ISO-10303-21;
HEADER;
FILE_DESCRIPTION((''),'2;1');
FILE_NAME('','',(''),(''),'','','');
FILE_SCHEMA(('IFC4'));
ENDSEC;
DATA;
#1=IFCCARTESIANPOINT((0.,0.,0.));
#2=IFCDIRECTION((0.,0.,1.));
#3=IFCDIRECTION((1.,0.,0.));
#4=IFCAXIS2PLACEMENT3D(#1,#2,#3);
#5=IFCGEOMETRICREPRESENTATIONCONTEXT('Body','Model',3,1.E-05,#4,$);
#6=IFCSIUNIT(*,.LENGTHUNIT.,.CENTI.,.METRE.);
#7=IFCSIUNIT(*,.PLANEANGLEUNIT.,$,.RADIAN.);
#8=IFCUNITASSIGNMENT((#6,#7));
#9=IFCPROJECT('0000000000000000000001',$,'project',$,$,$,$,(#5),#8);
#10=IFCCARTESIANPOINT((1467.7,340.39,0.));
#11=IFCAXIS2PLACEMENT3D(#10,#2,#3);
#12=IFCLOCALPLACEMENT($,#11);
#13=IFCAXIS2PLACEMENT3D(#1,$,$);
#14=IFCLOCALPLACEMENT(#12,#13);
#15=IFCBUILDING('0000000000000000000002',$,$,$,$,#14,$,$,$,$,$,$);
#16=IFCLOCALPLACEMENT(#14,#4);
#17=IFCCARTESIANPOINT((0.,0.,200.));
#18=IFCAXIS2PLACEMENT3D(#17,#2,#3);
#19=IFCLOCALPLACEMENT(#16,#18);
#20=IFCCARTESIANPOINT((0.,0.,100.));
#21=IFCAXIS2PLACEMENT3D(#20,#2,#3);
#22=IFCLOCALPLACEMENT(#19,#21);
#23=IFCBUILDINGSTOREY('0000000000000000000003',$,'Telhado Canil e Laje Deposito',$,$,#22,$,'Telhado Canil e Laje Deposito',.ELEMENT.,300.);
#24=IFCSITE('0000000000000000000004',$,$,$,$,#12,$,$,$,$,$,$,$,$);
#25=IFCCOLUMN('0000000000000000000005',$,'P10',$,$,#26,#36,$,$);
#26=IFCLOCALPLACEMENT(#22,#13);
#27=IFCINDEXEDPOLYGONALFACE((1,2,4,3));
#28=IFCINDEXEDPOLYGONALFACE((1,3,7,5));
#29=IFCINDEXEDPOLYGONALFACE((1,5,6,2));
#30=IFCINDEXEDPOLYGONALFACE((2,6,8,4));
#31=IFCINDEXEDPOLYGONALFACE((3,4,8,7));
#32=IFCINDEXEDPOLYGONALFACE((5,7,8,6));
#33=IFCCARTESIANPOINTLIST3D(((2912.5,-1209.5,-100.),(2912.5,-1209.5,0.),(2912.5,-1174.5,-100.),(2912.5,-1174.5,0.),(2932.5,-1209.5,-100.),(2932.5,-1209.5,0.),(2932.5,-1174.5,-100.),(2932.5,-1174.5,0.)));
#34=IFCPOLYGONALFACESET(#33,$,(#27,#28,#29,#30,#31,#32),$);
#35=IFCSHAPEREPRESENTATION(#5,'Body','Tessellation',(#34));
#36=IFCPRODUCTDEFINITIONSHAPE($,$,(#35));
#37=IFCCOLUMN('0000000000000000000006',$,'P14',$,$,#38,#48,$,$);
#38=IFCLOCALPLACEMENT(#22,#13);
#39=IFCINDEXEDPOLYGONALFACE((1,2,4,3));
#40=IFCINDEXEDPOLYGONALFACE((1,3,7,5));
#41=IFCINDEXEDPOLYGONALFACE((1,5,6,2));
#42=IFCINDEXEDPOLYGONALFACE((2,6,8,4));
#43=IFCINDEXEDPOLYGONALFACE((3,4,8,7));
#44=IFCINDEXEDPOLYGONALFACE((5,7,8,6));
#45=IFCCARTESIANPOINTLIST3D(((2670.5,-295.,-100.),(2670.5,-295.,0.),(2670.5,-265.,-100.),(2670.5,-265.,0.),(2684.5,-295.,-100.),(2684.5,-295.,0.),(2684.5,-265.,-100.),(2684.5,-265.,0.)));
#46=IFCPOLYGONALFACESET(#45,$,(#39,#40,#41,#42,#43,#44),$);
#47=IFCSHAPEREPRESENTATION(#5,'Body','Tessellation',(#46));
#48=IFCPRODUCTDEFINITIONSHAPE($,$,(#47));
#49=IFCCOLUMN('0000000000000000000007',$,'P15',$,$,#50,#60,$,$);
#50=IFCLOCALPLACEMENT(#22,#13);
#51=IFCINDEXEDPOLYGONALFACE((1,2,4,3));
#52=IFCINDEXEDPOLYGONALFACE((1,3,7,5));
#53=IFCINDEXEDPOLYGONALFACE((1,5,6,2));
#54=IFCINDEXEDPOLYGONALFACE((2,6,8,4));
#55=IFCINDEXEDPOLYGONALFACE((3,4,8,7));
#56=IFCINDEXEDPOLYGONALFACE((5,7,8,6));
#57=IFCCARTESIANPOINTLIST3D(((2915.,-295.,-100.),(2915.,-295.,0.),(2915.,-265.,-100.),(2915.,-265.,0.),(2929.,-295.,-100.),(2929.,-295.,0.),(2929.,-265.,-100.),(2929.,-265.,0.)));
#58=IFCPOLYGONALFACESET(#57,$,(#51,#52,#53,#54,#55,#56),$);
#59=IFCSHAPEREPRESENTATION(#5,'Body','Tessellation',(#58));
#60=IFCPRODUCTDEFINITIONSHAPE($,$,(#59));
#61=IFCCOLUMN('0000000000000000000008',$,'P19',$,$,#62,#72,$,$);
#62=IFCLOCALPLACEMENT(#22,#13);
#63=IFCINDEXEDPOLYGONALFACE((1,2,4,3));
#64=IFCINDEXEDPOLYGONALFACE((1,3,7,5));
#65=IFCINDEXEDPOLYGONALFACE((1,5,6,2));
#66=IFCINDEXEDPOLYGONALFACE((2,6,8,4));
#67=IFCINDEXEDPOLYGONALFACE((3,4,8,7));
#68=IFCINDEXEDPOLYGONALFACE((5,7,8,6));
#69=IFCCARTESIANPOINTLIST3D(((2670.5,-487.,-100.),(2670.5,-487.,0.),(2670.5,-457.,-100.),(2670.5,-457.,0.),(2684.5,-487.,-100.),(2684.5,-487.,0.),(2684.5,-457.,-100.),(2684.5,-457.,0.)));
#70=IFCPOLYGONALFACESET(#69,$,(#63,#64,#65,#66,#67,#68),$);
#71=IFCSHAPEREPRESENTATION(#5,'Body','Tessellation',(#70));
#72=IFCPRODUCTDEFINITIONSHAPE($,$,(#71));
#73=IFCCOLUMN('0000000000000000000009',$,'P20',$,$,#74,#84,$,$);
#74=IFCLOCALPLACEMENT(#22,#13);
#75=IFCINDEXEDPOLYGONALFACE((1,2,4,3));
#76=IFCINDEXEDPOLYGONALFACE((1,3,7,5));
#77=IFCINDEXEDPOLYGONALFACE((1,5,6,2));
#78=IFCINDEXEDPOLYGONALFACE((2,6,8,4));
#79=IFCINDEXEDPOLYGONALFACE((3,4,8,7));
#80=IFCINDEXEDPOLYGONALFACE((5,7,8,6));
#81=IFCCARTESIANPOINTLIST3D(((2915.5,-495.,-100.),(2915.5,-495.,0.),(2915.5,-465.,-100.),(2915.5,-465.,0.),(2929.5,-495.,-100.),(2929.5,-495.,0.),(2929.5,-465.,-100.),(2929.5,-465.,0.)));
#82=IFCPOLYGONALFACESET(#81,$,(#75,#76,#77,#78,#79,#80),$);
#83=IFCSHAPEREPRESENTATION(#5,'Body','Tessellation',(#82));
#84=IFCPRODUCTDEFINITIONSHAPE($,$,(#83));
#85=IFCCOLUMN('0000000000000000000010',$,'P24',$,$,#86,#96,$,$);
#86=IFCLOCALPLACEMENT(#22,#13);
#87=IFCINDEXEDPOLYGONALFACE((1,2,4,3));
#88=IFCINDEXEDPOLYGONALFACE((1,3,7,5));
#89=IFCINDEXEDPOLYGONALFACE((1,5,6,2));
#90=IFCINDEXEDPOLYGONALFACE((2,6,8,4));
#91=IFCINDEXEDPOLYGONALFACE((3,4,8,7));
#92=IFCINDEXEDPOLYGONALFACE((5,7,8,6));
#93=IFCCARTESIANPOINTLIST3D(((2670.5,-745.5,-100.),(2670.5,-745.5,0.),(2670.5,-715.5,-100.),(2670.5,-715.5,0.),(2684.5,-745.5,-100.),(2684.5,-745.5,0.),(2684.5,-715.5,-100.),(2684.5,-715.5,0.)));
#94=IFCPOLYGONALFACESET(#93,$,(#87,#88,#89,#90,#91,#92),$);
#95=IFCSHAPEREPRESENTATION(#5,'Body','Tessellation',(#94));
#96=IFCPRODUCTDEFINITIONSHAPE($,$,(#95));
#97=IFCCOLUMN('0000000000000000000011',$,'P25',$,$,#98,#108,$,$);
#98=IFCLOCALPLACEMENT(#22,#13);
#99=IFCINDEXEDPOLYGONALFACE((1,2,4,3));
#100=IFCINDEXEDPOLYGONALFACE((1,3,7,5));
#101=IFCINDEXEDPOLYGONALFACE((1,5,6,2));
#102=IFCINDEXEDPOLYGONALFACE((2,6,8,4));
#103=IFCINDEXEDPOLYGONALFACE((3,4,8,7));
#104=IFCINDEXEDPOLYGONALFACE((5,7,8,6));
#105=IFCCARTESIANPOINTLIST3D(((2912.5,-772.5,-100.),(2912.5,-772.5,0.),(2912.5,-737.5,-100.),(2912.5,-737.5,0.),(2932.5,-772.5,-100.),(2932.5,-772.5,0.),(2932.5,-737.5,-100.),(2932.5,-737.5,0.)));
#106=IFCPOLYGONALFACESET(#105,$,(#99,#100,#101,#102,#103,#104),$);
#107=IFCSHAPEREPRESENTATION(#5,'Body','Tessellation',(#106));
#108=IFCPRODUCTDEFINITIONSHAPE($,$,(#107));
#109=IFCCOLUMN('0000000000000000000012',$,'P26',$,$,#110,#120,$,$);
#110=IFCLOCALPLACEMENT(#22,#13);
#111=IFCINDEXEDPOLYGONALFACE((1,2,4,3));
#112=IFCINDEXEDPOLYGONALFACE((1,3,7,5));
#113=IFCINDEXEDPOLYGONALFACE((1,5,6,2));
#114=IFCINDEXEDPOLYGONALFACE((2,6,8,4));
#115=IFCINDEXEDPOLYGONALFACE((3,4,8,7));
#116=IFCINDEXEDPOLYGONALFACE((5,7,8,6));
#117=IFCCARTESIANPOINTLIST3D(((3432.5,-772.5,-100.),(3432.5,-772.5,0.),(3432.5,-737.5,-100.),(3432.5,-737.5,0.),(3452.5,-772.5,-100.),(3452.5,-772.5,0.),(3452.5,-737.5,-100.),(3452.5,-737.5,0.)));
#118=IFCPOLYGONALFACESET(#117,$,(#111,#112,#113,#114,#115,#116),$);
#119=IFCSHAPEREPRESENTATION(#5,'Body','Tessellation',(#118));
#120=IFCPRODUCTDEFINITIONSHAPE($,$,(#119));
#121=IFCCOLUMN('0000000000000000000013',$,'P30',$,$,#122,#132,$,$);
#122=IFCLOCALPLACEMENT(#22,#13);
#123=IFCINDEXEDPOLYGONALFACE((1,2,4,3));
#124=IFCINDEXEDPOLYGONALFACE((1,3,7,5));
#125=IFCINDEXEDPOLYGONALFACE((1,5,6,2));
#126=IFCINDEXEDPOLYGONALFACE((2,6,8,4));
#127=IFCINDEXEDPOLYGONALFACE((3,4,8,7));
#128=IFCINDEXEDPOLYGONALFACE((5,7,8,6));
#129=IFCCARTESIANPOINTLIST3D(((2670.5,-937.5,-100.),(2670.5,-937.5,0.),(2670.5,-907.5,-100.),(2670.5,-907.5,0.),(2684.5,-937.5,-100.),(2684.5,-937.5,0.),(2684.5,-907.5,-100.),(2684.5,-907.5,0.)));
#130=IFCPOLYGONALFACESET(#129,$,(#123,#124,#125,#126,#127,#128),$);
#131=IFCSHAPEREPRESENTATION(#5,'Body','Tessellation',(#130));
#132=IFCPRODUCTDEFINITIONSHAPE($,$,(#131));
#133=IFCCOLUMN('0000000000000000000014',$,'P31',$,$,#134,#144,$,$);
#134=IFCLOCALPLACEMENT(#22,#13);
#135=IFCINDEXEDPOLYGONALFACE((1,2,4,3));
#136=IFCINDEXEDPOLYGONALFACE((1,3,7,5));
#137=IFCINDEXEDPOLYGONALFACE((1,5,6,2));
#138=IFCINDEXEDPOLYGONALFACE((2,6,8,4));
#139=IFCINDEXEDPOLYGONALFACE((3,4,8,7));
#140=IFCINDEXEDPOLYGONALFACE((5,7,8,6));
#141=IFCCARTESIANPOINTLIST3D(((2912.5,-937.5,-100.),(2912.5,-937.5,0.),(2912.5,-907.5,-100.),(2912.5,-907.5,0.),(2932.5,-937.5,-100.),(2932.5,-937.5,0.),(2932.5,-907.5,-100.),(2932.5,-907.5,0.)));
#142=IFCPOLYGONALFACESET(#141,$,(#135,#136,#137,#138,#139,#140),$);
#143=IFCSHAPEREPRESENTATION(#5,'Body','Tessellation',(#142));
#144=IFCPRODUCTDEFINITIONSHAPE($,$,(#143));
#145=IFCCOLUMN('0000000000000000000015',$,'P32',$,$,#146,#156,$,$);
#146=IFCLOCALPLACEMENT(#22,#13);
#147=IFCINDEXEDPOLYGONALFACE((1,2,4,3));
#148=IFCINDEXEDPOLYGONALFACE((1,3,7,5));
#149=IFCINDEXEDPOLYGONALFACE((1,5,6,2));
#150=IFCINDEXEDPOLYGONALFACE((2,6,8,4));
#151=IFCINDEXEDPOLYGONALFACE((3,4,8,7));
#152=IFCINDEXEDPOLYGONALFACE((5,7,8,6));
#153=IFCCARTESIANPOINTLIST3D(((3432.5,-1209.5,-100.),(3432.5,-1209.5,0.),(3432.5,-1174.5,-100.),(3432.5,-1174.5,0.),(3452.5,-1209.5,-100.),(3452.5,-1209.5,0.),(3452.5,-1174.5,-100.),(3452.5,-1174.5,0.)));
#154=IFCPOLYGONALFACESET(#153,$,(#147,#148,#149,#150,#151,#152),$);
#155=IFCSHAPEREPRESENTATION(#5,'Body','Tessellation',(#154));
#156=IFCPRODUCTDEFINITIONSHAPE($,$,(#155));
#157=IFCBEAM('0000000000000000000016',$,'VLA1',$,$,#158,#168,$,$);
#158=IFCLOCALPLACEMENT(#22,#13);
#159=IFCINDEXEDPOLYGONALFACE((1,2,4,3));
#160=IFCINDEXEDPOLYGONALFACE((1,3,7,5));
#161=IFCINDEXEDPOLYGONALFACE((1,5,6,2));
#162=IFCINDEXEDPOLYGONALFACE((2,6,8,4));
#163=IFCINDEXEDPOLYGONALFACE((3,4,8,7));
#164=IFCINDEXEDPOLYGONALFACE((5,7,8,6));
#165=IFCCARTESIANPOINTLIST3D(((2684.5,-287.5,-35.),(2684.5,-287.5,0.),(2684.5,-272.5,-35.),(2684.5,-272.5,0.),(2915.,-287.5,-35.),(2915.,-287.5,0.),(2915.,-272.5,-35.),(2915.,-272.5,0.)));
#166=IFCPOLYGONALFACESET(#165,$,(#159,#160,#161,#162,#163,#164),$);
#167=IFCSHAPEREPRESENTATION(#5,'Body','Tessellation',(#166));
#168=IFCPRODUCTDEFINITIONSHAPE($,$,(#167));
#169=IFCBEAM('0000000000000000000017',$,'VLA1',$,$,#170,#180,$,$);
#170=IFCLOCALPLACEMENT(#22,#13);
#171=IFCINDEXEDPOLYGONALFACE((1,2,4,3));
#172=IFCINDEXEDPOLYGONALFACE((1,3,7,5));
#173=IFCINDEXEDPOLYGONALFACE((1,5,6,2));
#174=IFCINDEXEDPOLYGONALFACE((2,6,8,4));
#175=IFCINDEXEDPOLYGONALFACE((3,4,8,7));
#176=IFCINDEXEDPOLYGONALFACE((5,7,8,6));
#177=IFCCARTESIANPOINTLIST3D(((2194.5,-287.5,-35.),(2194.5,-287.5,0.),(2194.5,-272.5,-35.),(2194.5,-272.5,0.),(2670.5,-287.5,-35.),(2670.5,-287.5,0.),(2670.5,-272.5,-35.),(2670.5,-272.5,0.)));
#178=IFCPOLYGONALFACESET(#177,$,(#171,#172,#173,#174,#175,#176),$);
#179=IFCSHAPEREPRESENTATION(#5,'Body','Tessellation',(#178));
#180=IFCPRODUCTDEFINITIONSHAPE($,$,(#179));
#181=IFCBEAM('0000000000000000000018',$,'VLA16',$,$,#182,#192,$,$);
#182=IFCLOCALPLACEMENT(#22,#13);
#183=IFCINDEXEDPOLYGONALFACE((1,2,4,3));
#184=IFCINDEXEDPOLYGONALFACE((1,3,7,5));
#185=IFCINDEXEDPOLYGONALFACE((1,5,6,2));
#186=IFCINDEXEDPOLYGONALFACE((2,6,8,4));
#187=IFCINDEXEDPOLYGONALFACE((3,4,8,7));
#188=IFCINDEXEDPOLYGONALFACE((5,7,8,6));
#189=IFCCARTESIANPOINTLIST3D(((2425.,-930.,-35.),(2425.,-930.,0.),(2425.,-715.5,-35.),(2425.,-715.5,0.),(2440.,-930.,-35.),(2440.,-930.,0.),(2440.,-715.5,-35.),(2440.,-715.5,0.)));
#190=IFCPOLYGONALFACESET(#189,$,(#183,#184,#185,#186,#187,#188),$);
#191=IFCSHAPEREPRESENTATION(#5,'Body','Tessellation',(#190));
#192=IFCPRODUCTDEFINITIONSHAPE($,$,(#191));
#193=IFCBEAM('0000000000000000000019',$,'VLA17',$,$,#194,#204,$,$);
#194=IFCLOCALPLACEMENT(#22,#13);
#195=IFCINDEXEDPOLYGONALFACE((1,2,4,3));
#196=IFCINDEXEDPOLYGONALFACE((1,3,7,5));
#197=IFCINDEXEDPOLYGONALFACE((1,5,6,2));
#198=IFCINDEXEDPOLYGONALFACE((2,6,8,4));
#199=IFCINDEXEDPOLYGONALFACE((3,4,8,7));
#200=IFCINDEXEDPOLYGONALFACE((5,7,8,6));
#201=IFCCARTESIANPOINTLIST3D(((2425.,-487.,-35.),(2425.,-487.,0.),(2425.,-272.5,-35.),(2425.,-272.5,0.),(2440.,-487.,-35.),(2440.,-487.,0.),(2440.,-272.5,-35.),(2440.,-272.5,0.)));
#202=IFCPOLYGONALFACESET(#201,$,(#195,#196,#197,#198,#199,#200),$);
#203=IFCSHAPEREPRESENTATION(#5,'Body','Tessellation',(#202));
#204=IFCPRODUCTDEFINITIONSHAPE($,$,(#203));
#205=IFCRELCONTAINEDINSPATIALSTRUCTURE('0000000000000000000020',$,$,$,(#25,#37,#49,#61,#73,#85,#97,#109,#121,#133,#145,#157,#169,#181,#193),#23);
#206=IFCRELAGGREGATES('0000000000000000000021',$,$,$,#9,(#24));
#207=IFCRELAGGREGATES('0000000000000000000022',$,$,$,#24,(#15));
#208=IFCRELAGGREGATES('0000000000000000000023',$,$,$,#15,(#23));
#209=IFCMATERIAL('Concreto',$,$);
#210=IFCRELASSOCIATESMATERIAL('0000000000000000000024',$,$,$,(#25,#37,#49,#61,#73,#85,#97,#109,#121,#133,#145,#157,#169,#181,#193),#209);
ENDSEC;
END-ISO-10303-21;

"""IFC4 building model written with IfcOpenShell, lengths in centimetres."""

from ifc_helpers import new_model, si_unit, frame, origin, origin_with_axes, origin_2d_with_axis, place, context, project, spatial, rectangle, extrude, material, element, save


model = new_model("IFC4")

# Units and contexts
model_context = context("Model", 3, precision=1e-05, world=origin_with_axes(), identifier="Body")
ifc_project = project(units=[si_unit("LENGTHUNIT", "METRE", prefix="CENTI"), si_unit("PLANEANGLEUNIT", "RADIAN")], contexts=[model_context])

# Site, building, storey
site_placement = place(None, frame((1467.7, 340.39, 0.0), z_axis=(0.0, 0.0, 1.0), x_axis=(1.0, 0.0, 0.0)))
site = spatial("IfcSite", under=ifc_project, at=site_placement)
building_placement = place(site_placement, origin())
building = spatial("IfcBuilding", under=site, at=building_placement)
placement_1 = place(building_placement, origin_with_axes())
placement_2 = place(placement_1, frame((0.0, 0.0, 200.0), z_axis=(0.0, 0.0, 1.0), x_axis=(1.0, 0.0, 0.0)))
storey_placement = place(placement_2, frame((0.0, 0.0, 100.0), z_axis=(0.0, 0.0, 1.0), x_axis=(1.0, 0.0, 0.0)))
storey = spatial("IfcBuildingStorey", under=building, at=storey_placement, Name="Telhado Canil e Laje Deposito", LongName="Telhado Canil e Laje Deposito", CompositionType="ELEMENT", Elevation=300.0)

# Columns
ifc_material = material(Name="Concreto")
column_1_placement = place(storey_placement, frame((2922.5, -1192.0, 0.0), z_axis=(0.0, 0.0, 1.0), x_axis=(1.0, 0.0, 0.0)))
element("IfcColumn", 1, at=column_1_placement, inside=storey, material=ifc_material, Name="P10", context=model_context, shape_type="SolidModel", body=[
    extrude(rectangle(XDim=20.0, YDim=35.0, at=origin_2d_with_axis()), origin_with_axes(), (0.0, 0.0, -1.0), 100.0),
])
for number, where, z_axis, x_axis, name in (
    (2, (2677.5, -280.0, 0.0), (0.0, 0.0, 1.0), (1.0, 0.0, 0.0), "P14"),
    (3, (2922.0, -280.0, 0.0), (0.0, 0.0, 1.0), (1.0, 0.0, 0.0), "P15"),
):
    element("IfcColumn", number, at=place(storey_placement, frame(where, z_axis=z_axis, x_axis=x_axis)), inside=storey, material=ifc_material, Name=name, context=model_context, shape_type="SolidModel", body=[
        extrude(rectangle(XDim=14.0, YDim=30.0, at=origin_2d_with_axis()), origin_with_axes(), (0.0, 0.0, -1.0), 100.0),
    ])
column_2_placement = place(storey_placement, frame((2677.5, -472.0, 0.0), z_axis=(0.0, 0.0, 1.0), x_axis=(1.0, 0.0, 0.0)))
element("IfcColumn", 4, at=column_2_placement, inside=storey, material=ifc_material, Name="P19", context=model_context, shape_type="SolidModel", body=[
    extrude(rectangle(XDim=14.0, YDim=30.0, at=origin_2d_with_axis()), frame((0.0, 0.0, 0.0), z_axis=(0.0, 0.0, 1.0), x_axis=(-1.0, 0.0, 0.0)), (0.0, 0.0, -1.0), 100.0),
])
for number, where, z_axis, x_axis, name in (
    (5, (2922.5, -480.0, 0.0), (0.0, 0.0, 1.0), (1.0, 0.0, 0.0), "P20"),
    (6, (2677.5, -730.5, 0.0), (0.0, 0.0, 1.0), (1.0, 0.0, 0.0), "P24"),
):
    element("IfcColumn", number, at=place(storey_placement, frame(where, z_axis=z_axis, x_axis=x_axis)), inside=storey, material=ifc_material, Name=name, context=model_context, shape_type="SolidModel", body=[
        extrude(rectangle(XDim=14.0, YDim=30.0, at=origin_2d_with_axis()), origin_with_axes(), (0.0, 0.0, -1.0), 100.0),
    ])
column_3_placement = place(storey_placement, frame((2922.5, -755.0, 0.0), z_axis=(0.0, 0.0, 1.0), x_axis=(1.0, 0.0, 0.0)))
element("IfcColumn", 7, at=column_3_placement, inside=storey, material=ifc_material, Name="P25", context=model_context, shape_type="SolidModel", body=[
    extrude(rectangle(XDim=20.0, YDim=35.0, at=origin_2d_with_axis()), frame((0.0, 0.0, 0.0), z_axis=(0.0, 0.0, 1.0), x_axis=(-1.0, 0.0, 0.0)), (0.0, 0.0, -1.0), 100.0),
])
column_4_placement = place(storey_placement, frame((3442.5, -755.0, 0.0), z_axis=(0.0, 0.0, 1.0), x_axis=(1.0, 0.0, 0.0)))
element("IfcColumn", 8, at=column_4_placement, inside=storey, material=ifc_material, Name="P26", context=model_context, shape_type="SolidModel", body=[
    extrude(rectangle(XDim=20.0, YDim=35.0, at=origin_2d_with_axis()), origin_with_axes(), (0.0, 0.0, -1.0), 100.0),
])
column_5_placement = place(storey_placement, frame((2677.5, -922.5, 0.0), z_axis=(0.0, 0.0, 1.0), x_axis=(1.0, 0.0, 0.0)))
element("IfcColumn", 9, at=column_5_placement, inside=storey, material=ifc_material, Name="P30", context=model_context, shape_type="SolidModel", body=[
    extrude(rectangle(XDim=14.0, YDim=30.0, at=origin_2d_with_axis()), origin_with_axes(), (0.0, 0.0, -1.0), 100.0),
])
column_6_placement = place(storey_placement, frame((2922.5, -922.5, 0.0), z_axis=(0.0, 0.0, 1.0), x_axis=(1.0, 0.0, 0.0)))
element("IfcColumn", 10, at=column_6_placement, inside=storey, material=ifc_material, Name="P31", context=model_context, shape_type="SolidModel", body=[
    extrude(rectangle(XDim=20.0, YDim=30.0, at=origin_2d_with_axis()), origin_with_axes(), (0.0, 0.0, -1.0), 100.0),
])
column_7_placement = place(storey_placement, frame((3442.5, -1192.0, 0.0), z_axis=(0.0, 0.0, 1.0), x_axis=(1.0, 0.0, 0.0)))
element("IfcColumn", 11, at=column_7_placement, inside=storey, material=ifc_material, Name="P32", context=model_context, shape_type="SolidModel", body=[
    extrude(rectangle(XDim=20.0, YDim=35.0, at=origin_2d_with_axis()), origin_with_axes(), (0.0, 0.0, -1.0), 100.0),
])

# Beams
beam_1_placement = place(storey_placement, frame((2799.75, -280.0, 0.0), z_axis=(0.0, 0.0, 1.0), x_axis=(1.0, 0.0, 0.0)))
element("IfcBeam", 12, at=beam_1_placement, inside=storey, material=ifc_material, Name="VLA1", context=model_context, shape_type="SolidModel", body=[
    extrude(rectangle(XDim=15.0, YDim=35.0, at=origin_2d_with_axis()), frame((-115.25, 0.0, -17.5), z_axis=(1.0, 0.0, 0.0), x_axis=(0.0, 1.0, 0.0)), (0.0, 0.0, 1.0), 230.5),
])
beam_2_placement = place(storey_placement, frame((2432.5, -280.0, 0.0), z_axis=(0.0, 0.0, 1.0), x_axis=(1.0, 0.0, 0.0)))
element("IfcBeam", 13, at=beam_2_placement, inside=storey, material=ifc_material, Name="VLA1", context=model_context, shape_type="SolidModel", body=[
    extrude(rectangle(XDim=15.0, YDim=35.0, at=origin_2d_with_axis()), frame((-238.0, 0.0, -17.5), z_axis=(1.0, 0.0, 0.0), x_axis=(0.0, 1.0, 0.0)), (0.0, 0.0, 1.0), 476.0),
])
for number, where, z_axis, x_axis, name in (
    (14, (2432.5, -822.75, 0.0), (0.0, 0.0, 1.0), (1.0, 0.0, 0.0), "VLA16"),
    (15, (2432.5, -379.75, 0.0), (0.0, 0.0, 1.0), (1.0, 0.0, 0.0), "VLA17"),
):
    element("IfcBeam", number, at=place(storey_placement, frame(where, z_axis=z_axis, x_axis=x_axis)), inside=storey, material=ifc_material, Name=name, context=model_context, shape_type="SolidModel", body=[
        extrude(rectangle(XDim=15.0, YDim=35.0, at=origin_2d_with_axis()), frame((0.0, -107.25, -17.5), z_axis=(0.0, 1.0, 0.0), x_axis=(1.0, 0.0, 0.0)), (0.0, 0.0, 1.0), 214.5),
    ])

save(model, "model.ifc")
